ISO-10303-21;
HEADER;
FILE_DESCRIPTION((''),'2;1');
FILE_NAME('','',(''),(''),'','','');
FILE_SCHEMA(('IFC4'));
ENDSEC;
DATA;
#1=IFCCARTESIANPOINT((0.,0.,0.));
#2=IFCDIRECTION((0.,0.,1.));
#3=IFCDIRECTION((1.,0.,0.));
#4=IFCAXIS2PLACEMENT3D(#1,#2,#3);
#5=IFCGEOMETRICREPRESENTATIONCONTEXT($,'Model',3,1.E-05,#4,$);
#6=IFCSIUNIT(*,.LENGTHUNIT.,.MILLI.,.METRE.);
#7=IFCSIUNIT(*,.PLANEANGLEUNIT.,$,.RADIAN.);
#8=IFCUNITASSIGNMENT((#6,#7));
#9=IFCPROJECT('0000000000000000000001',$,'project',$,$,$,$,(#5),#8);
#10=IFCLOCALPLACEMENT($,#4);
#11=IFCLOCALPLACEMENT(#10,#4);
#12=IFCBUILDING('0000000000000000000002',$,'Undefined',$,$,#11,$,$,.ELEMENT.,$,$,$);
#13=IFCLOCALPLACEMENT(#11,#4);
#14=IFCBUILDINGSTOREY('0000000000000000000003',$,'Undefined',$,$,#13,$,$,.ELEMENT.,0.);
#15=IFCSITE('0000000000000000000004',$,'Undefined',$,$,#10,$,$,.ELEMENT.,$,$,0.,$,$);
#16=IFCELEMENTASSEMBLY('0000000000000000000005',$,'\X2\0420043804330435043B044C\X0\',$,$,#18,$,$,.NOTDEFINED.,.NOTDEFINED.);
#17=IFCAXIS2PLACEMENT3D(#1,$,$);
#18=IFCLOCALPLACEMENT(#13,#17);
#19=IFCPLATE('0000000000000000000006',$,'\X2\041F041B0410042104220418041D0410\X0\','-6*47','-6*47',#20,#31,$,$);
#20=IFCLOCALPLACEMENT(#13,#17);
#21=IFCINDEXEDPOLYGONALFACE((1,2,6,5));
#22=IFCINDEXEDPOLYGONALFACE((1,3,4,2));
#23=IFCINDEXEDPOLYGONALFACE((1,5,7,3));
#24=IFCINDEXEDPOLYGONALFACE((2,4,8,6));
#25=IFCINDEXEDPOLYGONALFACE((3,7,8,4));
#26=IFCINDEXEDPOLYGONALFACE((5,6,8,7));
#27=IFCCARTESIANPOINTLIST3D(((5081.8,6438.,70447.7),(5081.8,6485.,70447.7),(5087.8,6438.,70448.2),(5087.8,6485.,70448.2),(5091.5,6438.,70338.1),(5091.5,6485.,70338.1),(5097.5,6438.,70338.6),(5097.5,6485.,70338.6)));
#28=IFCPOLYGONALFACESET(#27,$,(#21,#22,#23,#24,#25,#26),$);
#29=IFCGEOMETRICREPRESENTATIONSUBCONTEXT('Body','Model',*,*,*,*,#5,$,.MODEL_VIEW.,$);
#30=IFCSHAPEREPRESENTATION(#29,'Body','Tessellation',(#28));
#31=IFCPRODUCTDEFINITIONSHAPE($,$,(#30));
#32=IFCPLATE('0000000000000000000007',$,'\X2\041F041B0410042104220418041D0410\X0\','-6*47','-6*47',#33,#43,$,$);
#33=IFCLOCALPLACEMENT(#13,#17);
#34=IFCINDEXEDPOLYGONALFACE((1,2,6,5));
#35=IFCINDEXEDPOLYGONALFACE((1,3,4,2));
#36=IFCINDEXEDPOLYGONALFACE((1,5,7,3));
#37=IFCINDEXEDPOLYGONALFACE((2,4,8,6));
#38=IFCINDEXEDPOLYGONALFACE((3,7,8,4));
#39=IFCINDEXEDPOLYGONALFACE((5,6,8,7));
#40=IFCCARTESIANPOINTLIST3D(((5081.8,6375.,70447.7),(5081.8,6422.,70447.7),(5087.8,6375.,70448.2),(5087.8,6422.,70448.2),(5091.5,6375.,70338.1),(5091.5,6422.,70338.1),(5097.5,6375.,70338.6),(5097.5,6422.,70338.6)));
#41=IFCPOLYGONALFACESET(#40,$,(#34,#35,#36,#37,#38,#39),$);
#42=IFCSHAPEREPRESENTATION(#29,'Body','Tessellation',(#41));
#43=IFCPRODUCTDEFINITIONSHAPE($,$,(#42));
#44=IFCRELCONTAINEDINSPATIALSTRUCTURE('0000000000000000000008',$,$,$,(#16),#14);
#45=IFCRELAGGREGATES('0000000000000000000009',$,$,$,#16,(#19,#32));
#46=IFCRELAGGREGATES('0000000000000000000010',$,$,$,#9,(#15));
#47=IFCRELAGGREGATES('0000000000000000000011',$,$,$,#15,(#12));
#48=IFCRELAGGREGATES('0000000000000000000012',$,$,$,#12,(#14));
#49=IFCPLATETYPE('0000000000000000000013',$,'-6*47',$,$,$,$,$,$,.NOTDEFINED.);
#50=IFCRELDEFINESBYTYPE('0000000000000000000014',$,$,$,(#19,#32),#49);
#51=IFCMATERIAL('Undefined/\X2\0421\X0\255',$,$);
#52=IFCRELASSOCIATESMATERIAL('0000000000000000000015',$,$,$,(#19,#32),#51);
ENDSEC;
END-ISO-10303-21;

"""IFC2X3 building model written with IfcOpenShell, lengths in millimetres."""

from ifc_helpers import new_model, si_unit, frame, origin_with_axes, origin_2d_with_axis, place, context, subcontext, project, spatial, polyline, rectangle, outline, extrude, boolean, material, type_object, element, aggregate, save


model = new_model("IFC2X3")

# Units and contexts
model_context = context("Model", 3, precision=1e-05, world=origin_with_axes())
body_context = subcontext(model_context, "Body", "Model", "MODEL_VIEW")
ifc_project = project(units=[si_unit("LENGTHUNIT", "METRE", prefix="MILLI"), si_unit("PLANEANGLEUNIT", "RADIAN")], contexts=[model_context])

# Site, building, storey
site_placement = place(None, origin_with_axes())
site = spatial("IfcSite", under=ifc_project, at=site_placement, Name="Undefined", CompositionType="ELEMENT", RefElevation=0.0)
building_placement = place(site_placement, origin_with_axes())
building = spatial("IfcBuilding", under=site, at=building_placement, Name="Undefined", CompositionType="ELEMENT")
storey_placement = place(building_placement, origin_with_axes())
storey = spatial("IfcBuildingStorey", under=building, at=storey_placement, Name="Undefined", CompositionType="ELEMENT", Elevation=0.0)

# Shared definitions
ifc_material_1 = material(Name="Undefined/С255")

# Element assembly
assembly_1_placement = place(storey_placement, origin_with_axes())
assembly_1 = element("IfcElementAssembly", 1, at=assembly_1_placement, inside=storey, Name="Ригель", AssemblyPlace="NOTDEFINED", PredefinedType="NOTDEFINED")

# Plates
plate_type = type_object("IfcPlateType", Name="-6*47", PredefinedType="NOTDEFINED")
plate_1_placement = place(assembly_1_placement, frame((5084.8, 6375.0, 70447.9), z_axis=(0.996107, 0.0, 0.088152), x_axis=(0.088152, 0.0, -0.996107)))
plate_1 = element("IfcPlate", 2, at=plate_1_placement, type_object=plate_type, material=ifc_material_1, Name="ПЛАСТИНА", Description="-6*47", ObjectType="-6*47", context=body_context, shape_type="CSG", body=[
    boolean("DIFFERENCE", extrude(outline(polyline([(0.0, 0.0), (110.0, 0.0), (110.0, 110.0), (0.0, 110.0), (0.0, 0.0)])), frame((0.0, 0.0, -3.0), z_axis=(0.0, 0.0, 1.0), x_axis=(1.0, 0.0, 0.0)), (0.0, 0.0, 1.0), 6.0), extrude(rectangle(XDim=26.0, YDim=130.0, at=origin_2d_with_axis()), frame((55.0, -3.0, 0.0), z_axis=(0.0, 1.0, 0.0), x_axis=(0.0, 0.0, -1.0)), (0.0, 0.0, 1.0), 66.0)),
])
plate_2_placement = place(assembly_1_placement, frame((5084.8, 6375.0, 70447.9), z_axis=(0.996107, 0.0, 0.088152), x_axis=(0.088152, 0.0, -0.996107)))
plate_2 = element("IfcPlate", 3, at=plate_2_placement, type_object=plate_type, material=ifc_material_1, Name="ПЛАСТИНА", Description="-6*47", ObjectType="-6*47", context=body_context, shape_type="CSG", body=[
    boolean("DIFFERENCE", extrude(outline(polyline([(0.0, 0.0), (110.0, 0.0), (110.0, 110.0), (0.0, 110.0), (0.0, 0.0)])), frame((0.0, 0.0, -3.0), z_axis=(0.0, 0.0, 1.0), x_axis=(1.0, 0.0, 0.0)), (0.0, 0.0, 1.0), 6.0), extrude(rectangle(XDim=26.0, YDim=130.0, at=origin_2d_with_axis()), frame((55.0, 47.0, 0.0), z_axis=(0.0, 1.0, 0.0), x_axis=(0.0, 0.0, -1.0)), (0.0, 0.0, 1.0), 66.0)),
])

aggregate(assembly_1, [plate_1, plate_2])

save(model, "model.ifc")
